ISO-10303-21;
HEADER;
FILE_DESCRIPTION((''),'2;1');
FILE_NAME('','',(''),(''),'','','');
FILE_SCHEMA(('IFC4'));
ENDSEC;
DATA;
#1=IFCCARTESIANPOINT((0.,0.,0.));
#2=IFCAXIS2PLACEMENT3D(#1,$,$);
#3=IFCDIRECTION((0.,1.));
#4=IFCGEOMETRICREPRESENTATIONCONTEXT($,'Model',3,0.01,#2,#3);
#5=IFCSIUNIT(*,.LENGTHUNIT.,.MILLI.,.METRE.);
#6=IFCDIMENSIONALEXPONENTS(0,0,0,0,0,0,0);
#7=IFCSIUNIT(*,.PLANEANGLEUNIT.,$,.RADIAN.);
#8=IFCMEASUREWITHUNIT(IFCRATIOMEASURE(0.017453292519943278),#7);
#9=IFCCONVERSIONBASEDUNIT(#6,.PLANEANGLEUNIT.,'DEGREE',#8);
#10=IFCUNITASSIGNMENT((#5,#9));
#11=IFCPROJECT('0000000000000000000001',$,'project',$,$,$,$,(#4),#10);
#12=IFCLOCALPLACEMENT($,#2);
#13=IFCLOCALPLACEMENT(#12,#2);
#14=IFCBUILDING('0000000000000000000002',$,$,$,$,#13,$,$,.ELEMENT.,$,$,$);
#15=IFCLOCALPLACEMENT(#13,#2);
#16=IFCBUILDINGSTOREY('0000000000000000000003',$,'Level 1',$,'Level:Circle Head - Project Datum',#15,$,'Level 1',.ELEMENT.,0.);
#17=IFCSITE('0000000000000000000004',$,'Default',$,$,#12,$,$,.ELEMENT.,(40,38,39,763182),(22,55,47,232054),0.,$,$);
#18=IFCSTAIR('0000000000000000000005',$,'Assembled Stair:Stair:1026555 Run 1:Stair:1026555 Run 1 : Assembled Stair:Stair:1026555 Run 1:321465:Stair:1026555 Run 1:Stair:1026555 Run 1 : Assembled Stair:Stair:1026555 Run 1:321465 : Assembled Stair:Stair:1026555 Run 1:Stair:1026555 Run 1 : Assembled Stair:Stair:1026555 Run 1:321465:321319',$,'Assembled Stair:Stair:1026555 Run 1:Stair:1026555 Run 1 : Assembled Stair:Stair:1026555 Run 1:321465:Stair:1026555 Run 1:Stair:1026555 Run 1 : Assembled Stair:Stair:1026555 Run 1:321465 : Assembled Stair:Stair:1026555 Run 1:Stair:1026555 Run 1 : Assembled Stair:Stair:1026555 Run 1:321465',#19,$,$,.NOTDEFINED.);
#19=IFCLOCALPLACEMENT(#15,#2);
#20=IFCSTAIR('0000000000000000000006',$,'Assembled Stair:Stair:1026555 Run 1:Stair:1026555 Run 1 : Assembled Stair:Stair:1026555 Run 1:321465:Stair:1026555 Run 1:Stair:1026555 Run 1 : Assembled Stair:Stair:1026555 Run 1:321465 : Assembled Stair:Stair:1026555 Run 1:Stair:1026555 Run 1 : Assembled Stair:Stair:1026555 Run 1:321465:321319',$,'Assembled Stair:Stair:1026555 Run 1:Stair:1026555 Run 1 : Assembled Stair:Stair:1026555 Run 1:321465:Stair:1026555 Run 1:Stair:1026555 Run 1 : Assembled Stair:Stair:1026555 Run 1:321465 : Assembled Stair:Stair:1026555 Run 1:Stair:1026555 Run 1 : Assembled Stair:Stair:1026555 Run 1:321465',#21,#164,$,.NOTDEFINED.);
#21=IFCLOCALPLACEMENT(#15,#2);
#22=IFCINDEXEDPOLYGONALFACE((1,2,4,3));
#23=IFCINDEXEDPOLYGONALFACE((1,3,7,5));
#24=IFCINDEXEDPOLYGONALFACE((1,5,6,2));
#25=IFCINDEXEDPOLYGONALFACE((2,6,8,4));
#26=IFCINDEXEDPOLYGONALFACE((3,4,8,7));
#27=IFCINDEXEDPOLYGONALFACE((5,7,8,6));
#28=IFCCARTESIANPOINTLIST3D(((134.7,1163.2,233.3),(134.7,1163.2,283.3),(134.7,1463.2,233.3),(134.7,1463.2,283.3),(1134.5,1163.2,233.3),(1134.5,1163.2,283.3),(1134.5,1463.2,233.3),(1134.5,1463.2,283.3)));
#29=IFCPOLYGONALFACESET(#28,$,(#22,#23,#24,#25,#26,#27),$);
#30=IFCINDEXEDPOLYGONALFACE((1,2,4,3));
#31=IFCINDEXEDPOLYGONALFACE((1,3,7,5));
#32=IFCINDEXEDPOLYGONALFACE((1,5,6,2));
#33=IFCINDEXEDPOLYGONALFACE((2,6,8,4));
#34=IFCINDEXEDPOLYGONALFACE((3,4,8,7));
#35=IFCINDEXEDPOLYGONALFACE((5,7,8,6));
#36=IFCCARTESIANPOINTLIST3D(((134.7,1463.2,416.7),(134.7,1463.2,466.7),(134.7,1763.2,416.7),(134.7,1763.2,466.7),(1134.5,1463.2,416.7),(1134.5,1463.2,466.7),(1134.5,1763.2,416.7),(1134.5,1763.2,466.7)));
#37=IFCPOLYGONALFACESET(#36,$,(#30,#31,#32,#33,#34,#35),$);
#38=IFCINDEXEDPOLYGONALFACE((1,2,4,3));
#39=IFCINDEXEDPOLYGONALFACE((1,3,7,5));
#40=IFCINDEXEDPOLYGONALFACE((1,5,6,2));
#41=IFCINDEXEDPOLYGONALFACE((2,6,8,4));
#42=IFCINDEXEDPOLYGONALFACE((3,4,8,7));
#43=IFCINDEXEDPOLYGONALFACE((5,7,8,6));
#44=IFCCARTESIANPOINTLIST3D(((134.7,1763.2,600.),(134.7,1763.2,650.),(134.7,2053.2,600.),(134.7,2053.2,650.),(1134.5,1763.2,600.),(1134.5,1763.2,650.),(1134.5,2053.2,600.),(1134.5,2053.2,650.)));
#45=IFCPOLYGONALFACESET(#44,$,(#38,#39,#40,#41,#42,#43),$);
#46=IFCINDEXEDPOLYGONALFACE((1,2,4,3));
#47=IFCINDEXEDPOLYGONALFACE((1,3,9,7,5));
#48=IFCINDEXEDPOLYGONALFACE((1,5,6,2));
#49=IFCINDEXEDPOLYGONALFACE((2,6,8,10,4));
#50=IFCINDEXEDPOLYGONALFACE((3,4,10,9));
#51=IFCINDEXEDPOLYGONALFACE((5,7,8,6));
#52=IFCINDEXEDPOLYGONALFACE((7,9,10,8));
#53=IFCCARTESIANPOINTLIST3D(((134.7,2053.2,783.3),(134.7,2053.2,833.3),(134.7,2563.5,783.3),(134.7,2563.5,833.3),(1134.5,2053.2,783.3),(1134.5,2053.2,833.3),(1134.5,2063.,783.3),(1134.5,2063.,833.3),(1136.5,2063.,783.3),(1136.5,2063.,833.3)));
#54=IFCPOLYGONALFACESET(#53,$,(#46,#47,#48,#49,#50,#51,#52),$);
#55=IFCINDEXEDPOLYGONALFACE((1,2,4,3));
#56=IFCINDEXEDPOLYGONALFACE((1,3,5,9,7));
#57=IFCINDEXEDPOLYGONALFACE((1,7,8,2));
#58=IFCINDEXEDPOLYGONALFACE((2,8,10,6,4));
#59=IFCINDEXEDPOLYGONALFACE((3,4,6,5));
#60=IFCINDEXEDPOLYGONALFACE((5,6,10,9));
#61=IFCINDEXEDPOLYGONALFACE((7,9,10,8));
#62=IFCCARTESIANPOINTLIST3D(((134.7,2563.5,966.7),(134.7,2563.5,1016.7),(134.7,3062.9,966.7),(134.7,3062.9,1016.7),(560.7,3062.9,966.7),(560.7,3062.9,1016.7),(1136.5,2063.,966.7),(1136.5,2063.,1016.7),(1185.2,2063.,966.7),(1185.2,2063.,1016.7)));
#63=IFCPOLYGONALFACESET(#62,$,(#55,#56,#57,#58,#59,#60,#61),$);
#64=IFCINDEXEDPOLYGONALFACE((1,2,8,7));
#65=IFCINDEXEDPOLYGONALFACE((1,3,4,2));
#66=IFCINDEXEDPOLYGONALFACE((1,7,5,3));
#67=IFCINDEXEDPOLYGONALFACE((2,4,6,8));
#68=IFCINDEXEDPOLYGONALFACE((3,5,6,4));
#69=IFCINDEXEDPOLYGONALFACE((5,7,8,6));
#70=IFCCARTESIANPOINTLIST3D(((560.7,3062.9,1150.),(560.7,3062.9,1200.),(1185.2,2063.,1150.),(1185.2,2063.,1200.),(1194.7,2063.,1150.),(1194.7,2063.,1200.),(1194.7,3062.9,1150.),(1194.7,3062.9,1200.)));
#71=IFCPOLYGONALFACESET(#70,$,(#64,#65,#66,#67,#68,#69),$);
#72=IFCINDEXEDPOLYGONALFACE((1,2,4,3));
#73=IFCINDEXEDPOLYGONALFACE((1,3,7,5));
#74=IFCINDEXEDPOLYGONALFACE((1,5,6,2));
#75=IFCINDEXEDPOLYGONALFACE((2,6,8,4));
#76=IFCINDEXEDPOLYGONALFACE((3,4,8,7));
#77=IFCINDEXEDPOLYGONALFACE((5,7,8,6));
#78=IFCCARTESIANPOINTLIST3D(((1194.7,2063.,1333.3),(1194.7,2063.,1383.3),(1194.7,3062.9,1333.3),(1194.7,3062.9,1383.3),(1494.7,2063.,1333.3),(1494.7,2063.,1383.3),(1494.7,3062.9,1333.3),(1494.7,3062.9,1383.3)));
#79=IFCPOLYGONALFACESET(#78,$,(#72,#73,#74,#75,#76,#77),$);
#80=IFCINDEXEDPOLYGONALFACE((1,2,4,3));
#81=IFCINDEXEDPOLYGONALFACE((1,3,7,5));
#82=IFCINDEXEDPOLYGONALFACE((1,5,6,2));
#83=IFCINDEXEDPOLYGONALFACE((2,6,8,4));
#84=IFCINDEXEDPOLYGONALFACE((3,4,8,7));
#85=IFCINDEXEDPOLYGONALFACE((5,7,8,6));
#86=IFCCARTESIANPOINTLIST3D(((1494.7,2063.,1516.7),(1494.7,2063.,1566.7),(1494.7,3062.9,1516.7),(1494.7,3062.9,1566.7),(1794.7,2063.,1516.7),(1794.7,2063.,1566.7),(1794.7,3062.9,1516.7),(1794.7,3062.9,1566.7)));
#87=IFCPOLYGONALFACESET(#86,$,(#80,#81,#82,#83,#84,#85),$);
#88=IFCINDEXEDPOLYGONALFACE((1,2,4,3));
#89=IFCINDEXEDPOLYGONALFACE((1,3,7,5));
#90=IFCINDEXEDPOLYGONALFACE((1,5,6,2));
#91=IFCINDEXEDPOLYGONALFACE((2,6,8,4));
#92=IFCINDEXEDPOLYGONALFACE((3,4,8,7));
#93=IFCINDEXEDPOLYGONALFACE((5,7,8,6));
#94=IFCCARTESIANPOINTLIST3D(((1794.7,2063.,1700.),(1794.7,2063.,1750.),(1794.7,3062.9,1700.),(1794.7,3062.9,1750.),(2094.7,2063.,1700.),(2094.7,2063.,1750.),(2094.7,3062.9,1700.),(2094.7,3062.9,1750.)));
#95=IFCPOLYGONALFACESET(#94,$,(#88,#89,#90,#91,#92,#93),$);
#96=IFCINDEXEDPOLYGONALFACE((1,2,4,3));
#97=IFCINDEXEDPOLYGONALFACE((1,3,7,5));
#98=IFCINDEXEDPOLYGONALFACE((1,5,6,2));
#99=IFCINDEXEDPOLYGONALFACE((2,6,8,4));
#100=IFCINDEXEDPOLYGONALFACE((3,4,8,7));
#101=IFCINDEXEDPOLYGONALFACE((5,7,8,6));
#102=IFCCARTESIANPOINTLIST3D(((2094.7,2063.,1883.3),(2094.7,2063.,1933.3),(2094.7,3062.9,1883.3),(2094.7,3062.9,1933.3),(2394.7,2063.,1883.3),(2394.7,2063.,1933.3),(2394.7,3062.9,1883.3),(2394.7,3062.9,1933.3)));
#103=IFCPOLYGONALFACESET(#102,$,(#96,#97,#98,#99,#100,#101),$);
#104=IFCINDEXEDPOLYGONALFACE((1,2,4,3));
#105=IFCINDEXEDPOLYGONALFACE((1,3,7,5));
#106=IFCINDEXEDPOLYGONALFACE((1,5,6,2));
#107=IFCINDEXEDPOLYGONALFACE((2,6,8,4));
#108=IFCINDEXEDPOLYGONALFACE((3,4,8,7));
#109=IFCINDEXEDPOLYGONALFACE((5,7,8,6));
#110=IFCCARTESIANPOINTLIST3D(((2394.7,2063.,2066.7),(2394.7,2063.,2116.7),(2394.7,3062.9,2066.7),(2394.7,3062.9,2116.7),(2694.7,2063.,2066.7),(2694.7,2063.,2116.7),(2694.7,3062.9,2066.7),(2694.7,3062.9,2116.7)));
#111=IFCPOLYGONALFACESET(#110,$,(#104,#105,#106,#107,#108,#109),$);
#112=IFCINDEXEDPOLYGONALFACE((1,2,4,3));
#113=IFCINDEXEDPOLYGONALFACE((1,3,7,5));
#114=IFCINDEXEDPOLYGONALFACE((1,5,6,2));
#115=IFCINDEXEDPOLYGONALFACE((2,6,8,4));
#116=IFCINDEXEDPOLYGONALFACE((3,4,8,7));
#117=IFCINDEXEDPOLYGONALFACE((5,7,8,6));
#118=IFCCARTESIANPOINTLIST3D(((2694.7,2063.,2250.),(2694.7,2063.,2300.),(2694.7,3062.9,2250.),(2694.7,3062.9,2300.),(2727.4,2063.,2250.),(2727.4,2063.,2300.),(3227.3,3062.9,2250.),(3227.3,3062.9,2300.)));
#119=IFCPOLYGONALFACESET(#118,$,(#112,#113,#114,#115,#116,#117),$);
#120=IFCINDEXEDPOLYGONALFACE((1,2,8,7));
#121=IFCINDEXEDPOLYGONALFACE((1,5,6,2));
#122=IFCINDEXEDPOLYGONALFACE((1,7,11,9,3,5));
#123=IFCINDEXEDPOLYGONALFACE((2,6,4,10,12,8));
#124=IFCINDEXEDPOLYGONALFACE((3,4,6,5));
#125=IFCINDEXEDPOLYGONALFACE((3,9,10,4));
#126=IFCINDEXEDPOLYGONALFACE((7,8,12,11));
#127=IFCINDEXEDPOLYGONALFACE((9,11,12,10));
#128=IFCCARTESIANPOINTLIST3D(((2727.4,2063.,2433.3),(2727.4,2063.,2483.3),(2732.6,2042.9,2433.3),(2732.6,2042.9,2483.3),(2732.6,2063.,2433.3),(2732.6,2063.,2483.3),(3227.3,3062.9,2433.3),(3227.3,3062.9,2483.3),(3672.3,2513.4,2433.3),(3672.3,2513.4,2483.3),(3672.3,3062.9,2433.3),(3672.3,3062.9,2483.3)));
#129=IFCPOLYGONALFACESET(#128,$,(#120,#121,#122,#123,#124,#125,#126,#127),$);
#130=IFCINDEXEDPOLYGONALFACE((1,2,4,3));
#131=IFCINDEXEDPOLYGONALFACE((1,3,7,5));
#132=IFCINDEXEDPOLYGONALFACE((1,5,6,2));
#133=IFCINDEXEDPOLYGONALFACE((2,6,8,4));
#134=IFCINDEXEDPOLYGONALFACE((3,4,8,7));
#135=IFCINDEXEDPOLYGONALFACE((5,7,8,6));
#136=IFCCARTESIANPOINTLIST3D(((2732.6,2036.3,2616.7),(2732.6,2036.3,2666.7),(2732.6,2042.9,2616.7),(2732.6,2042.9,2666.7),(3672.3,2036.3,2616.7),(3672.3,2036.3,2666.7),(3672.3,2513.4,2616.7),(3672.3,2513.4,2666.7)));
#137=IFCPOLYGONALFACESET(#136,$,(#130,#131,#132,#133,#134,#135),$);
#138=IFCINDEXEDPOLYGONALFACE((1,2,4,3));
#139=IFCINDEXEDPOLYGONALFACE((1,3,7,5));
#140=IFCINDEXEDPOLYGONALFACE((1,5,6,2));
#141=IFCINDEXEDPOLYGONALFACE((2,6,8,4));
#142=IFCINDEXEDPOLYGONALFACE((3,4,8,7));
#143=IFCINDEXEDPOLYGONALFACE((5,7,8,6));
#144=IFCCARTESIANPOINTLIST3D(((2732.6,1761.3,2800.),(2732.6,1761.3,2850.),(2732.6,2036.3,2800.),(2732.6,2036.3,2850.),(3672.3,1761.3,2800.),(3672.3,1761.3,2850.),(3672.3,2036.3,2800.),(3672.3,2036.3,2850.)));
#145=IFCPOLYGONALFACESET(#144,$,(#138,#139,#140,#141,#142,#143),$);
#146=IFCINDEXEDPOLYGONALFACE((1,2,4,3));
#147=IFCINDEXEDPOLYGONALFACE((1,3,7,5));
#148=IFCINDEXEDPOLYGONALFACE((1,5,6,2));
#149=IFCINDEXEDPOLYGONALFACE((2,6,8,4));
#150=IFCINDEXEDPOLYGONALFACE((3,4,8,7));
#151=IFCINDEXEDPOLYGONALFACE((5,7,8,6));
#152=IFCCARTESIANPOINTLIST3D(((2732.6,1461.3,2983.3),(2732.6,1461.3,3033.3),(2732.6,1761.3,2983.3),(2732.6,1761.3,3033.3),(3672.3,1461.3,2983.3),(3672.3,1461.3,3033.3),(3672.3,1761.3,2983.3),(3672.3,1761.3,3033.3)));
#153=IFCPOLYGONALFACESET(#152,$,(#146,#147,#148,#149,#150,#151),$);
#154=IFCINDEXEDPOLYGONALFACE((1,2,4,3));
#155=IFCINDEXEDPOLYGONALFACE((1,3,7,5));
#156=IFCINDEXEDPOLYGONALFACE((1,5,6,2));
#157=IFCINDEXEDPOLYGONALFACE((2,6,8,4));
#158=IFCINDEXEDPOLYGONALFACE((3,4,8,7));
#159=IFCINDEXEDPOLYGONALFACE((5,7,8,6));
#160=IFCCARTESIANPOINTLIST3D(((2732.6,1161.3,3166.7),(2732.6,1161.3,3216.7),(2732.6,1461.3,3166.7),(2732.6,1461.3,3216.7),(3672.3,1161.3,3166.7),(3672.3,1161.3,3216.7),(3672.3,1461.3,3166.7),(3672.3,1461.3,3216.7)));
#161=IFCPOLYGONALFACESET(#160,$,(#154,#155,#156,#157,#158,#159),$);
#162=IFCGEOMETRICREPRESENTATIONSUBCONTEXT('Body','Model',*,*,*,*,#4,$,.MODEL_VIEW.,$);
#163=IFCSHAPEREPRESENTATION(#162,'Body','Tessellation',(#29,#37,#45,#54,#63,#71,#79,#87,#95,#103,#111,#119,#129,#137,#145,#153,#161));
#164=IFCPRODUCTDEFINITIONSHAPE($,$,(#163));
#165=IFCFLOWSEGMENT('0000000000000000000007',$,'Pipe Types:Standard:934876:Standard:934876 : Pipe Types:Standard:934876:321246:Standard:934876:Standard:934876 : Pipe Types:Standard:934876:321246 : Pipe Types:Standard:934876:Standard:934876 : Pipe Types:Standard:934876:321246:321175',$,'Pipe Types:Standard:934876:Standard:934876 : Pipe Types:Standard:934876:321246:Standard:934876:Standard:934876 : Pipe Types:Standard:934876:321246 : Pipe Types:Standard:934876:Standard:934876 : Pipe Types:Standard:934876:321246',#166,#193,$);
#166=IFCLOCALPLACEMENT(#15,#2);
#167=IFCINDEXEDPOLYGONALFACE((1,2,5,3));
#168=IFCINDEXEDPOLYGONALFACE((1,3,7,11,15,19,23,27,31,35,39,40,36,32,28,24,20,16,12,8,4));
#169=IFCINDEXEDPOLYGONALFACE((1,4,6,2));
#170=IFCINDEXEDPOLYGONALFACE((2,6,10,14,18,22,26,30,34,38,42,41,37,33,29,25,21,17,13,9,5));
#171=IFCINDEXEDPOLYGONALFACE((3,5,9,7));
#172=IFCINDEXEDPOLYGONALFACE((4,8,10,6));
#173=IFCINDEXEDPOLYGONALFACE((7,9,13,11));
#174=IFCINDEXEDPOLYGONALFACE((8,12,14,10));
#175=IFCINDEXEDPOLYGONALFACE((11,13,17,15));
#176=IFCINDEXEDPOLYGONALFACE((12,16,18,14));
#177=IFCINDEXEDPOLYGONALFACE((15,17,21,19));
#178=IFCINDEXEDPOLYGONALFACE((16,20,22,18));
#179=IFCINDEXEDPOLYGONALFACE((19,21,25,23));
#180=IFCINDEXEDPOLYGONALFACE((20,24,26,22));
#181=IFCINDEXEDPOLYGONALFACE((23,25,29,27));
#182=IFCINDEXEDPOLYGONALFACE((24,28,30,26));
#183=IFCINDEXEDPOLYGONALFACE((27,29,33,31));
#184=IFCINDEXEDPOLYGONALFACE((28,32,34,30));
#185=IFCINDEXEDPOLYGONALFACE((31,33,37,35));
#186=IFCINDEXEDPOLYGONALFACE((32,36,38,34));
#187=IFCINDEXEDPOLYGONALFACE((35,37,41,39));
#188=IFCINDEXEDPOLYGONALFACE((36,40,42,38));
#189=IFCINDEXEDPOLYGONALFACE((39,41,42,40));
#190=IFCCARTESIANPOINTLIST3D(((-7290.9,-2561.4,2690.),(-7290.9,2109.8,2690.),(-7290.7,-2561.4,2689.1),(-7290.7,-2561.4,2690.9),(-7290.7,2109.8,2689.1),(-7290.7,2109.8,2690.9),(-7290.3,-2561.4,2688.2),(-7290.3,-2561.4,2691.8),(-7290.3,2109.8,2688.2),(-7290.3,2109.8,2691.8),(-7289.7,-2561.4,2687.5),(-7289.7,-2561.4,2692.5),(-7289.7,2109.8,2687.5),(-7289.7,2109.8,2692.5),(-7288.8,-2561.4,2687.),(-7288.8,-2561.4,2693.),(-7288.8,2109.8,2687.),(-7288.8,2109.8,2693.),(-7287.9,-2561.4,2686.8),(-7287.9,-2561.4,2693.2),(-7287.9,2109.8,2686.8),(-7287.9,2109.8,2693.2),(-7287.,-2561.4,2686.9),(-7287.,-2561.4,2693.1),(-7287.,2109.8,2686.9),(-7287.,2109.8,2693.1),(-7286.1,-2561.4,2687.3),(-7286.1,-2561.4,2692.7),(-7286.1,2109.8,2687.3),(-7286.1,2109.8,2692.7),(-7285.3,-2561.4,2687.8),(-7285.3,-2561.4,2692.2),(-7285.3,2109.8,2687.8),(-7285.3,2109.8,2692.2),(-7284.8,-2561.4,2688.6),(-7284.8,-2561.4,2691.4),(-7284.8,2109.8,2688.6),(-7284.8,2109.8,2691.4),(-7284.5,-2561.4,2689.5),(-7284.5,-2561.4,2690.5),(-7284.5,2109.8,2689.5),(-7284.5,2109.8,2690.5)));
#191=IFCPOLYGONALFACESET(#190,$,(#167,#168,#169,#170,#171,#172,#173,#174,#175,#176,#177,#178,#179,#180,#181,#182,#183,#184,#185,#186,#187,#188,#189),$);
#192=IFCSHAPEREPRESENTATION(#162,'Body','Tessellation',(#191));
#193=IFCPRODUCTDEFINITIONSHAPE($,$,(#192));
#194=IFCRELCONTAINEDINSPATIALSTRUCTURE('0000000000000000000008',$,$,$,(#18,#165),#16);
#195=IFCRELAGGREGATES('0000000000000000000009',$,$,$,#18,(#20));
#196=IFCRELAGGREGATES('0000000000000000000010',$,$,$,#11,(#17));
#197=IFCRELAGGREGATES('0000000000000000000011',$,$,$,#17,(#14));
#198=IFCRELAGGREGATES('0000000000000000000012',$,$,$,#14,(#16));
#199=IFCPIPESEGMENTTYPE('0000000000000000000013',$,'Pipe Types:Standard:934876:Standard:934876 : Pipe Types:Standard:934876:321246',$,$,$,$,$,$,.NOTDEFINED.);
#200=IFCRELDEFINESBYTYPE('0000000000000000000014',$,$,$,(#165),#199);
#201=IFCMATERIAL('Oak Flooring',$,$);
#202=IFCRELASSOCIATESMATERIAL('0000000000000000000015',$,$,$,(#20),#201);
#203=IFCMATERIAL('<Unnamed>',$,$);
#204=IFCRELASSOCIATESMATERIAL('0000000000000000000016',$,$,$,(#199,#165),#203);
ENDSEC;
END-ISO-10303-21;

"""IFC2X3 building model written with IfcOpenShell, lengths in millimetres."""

from ifc_helpers import new_model, entity, si_unit, converted_unit, direction, frame, frame_2d, origin, origin_2d_with_axis, place, context, subcontext, project, spatial, polyline, rectangle, circle, outline, extrude, source, transform, mapped, material, type_object, type_shapes, element, aggregate, save


model = new_model("IFC2X3")

# Units and contexts
model_context = context("Model", 3, precision=0.01, world=origin(), true_north=direction((0.0, 1.0)))
body_context = subcontext(model_context, "Body", "Model", "MODEL_VIEW")
ifc_project = project(units=[si_unit("LENGTHUNIT", "METRE", prefix="MILLI"), converted_unit("PLANEANGLEUNIT", "DEGREE", entity("IfcRatioMeasure", 0.017453292519943278), si_unit("PLANEANGLEUNIT", "RADIAN"), dimensions=[0, 0, 0, 0, 0, 0, 0])], contexts=[model_context])

# Site, building, storey
site_placement = place(None, origin())
site = spatial("IfcSite", under=ifc_project, at=site_placement, Name="Default", CompositionType="ELEMENT", RefLatitude=(40, 38, 39, 763182), RefLongitude=(22, 55, 47, 232054), RefElevation=0.0)
building_placement = place(site_placement, origin())
building = spatial("IfcBuilding", under=site, at=building_placement, CompositionType="ELEMENT")
storey_placement = place(building_placement, origin())
storey = spatial("IfcBuildingStorey", under=building, at=storey_placement, Name="Level 1", ObjectType="Level:Circle Head - Project Datum", LongName="Level 1", CompositionType="ELEMENT", Elevation=0.0)

# Stairs
stair_1_placement = place(storey_placement, origin())
stair_1 = element("IfcStair", 1, at=stair_1_placement, inside=storey, Name="Assembled Stair:Stair:1026555 Run 1:Stair:1026555 Run 1 : Assembled Stair:Stair:1026555 Run 1:321465:Stair:1026555 Run 1:Stair:1026555 Run 1 : Assembled Stair:Stair:1026555 Run 1:321465 : Assembled Stair:Stair:1026555 Run 1:Stair:1026555 Run 1 : Assembled Stair:Stair:1026555 Run 1:321465:321319", ObjectType="Assembled Stair:Stair:1026555 Run 1:Stair:1026555 Run 1 : Assembled Stair:Stair:1026555 Run 1:321465:Stair:1026555 Run 1:Stair:1026555 Run 1 : Assembled Stair:Stair:1026555 Run 1:321465 : Assembled Stair:Stair:1026555 Run 1:Stair:1026555 Run 1 : Assembled Stair:Stair:1026555 Run 1:321465", ShapeType="NOTDEFINED")
ifc_material_1 = material(Name="Oak Flooring")
stair_2_placement = place(stair_1_placement, origin())
stair_2 = element("IfcStair", 2, at=stair_2_placement, material=ifc_material_1, Name="Assembled Stair:Stair:1026555 Run 1:Stair:1026555 Run 1 : Assembled Stair:Stair:1026555 Run 1:321465:Stair:1026555 Run 1:Stair:1026555 Run 1 : Assembled Stair:Stair:1026555 Run 1:321465 : Assembled Stair:Stair:1026555 Run 1:Stair:1026555 Run 1 : Assembled Stair:Stair:1026555 Run 1:321465:321319", ObjectType="Assembled Stair:Stair:1026555 Run 1:Stair:1026555 Run 1 : Assembled Stair:Stair:1026555 Run 1:321465:Stair:1026555 Run 1:Stair:1026555 Run 1 : Assembled Stair:Stair:1026555 Run 1:321465 : Assembled Stair:Stair:1026555 Run 1:Stair:1026555 Run 1 : Assembled Stair:Stair:1026555 Run 1:321465", ShapeType="NOTDEFINED", context=body_context, shape_type="SweptSolid", body=[
    extrude(rectangle(XDim=300.0, YDim=999.8, at=frame_2d((0.0, 0.0), x_axis=(1.0, 0.0))), frame((634.6, 1313.2, 233.3), z_axis=(0.0, 0.0, 1.0), x_axis=(0.0, 1.0, 0.0)), (0.0, 0.0, 1.0), 50.0),
    extrude(rectangle(XDim=300.0, YDim=999.8, at=origin_2d_with_axis()), frame((634.6, 1613.2, 416.7), z_axis=(0.0, 0.0, 1.0), x_axis=(0.0, 1.0, 0.0)), (0.0, 0.0, 1.0), 50.0),
    extrude(rectangle(XDim=290.0, YDim=999.8, at=frame_2d((0.0, 0.0), x_axis=(1.0, 0.0))), frame((634.6, 1908.2, 600.0), z_axis=(0.0, 0.0, 1.0), x_axis=(0.0, 1.0, 0.0)), (0.0, 0.0, 1.0), 50.0),
    extrude(outline(polyline([(-106.0, 399.5), (-106.0, -600.3), (404.3, -600.3), (-96.1, 401.5), (-96.1, 399.5), (-106.0, 399.5)])), frame((735.0, 2159.2, 783.3), z_axis=(0.0, 0.0, -1.0), x_axis=(0.0, 1.0, 0.0)), (0.0, 0.0, -1.0), 50.0),
    extrude(outline(polyline([(-443.6, -221.2), (676.2, -221.2), (719.8, -199.4), (-285.7, 416.0), (-666.8, 225.7), (-443.6, -221.2)])), frame((630.4, 2563.1, 966.7), z_axis=(0.0, 0.0, 1.0), x_axis=(0.894584, -0.446899, 0.0)), (0.0, 0.0, 1.0), 50.0),
    extrude(outline(polyline([(151.4, -499.9), (160.9, -499.9), (160.9, 499.9), (-473.1, 499.9), (151.4, -499.9)])), frame((1033.8, 2563.0, 1150.0)), (0.0, 0.0, 1.0), 50.0),
    extrude(rectangle(XDim=300.0, YDim=999.9, at=frame_2d((0.0, 0.0), x_axis=(1.0, 0.0))), frame((1344.7, 2563.0, 1333.3)), (0.0, 0.0, 1.0), 50.0),
    extrude(rectangle(XDim=300.0, YDim=999.9, at=frame_2d((0.0, 0.0), x_axis=(1.0, 0.0))), frame((1644.7, 2563.0, 1516.7)), (0.0, 0.0, 1.0), 50.0),
    extrude(rectangle(XDim=300.0, YDim=999.9, at=frame_2d((0.0, 0.0), x_axis=(1.0, 0.0))), frame((1944.7, 2563.0, 1700.0)), (0.0, 0.0, 1.0), 50.0),
    extrude(rectangle(XDim=300.0, YDim=999.9, at=frame_2d((0.0, 0.0), x_axis=(1.0, 0.0))), frame((2244.7, 2563.0, 1883.3)), (0.0, 0.0, 1.0), 50.0),
    extrude(rectangle(XDim=300.0, YDim=999.9, at=frame_2d((0.0, 0.0), x_axis=(1.0, 0.0))), frame((2544.7, 2563.0, 2066.7)), (0.0, 0.0, 1.0), 50.0),
    extrude(outline(polyline([(-141.3, -499.9), (-108.6, -499.9), (391.3, 499.9), (-141.3, 499.9), (-141.3, -499.9)])), frame((2836.0, 2563.0, 2250.0)), (0.0, 0.0, 1.0), 50.0),
    extrude(outline(polyline([(-576.8, -176.7), (541.1, -176.7), (538.8, -172.0), (556.8, -163.0), (-284.2, 467.1), (-775.8, 221.3), (-576.8, -176.7)])), frame((3127.4, 2468.0, 2433.3), z_axis=(0.0, 0.0, 1.0), x_axis=(-0.447218, -0.894425, 0.0)), (0.0, 0.0, 1.0), 50.0),
    extrude(outline(polyline([(114.3, -469.8), (120.9, -469.8), (120.9, 469.8), (-356.2, 469.8), (114.3, -469.8)])), frame((3202.4, 2157.2, 2616.7), z_axis=(0.0, 0.0, 1.0), x_axis=(0.0, -1.0, 0.0)), (0.0, 0.0, 1.0), 50.0),
    extrude(rectangle(XDim=275.0, YDim=939.7, at=frame_2d((0.0, 0.0), x_axis=(1.0, 0.0))), frame((3202.4, 1898.8, 2800.0), z_axis=(0.0, 0.0, 1.0), x_axis=(0.0, -1.0, 0.0)), (0.0, 0.0, 1.0), 50.0),
    extrude(rectangle(XDim=300.0, YDim=939.7, at=frame_2d((0.0, 0.0), x_axis=(1.0, 0.0))), frame((3202.4, 1611.3, 2983.3), z_axis=(0.0, 0.0, 1.0), x_axis=(0.0, -1.0, 0.0)), (0.0, 0.0, 1.0), 50.0),
    extrude(rectangle(XDim=300.0, YDim=939.7, at=frame_2d((0.0, 0.0), x_axis=(1.0, 0.0))), frame((3202.4, 1311.3, 3166.7), z_axis=(0.0, 0.0, 1.0), x_axis=(0.0, -1.0, 0.0)), (0.0, 0.0, 1.0), 50.0),
])
aggregate(stair_1, [stair_2])

# Flow segment
ifc_material_2 = material(Name="<Unnamed>")
pipe_segment_type_1 = type_object("IfcPipeSegmentType", Name="Pipe Types:Standard:934876:Standard:934876 : Pipe Types:Standard:934876:321246", PredefinedType="NOTDEFINED", material=ifc_material_2)
shared_shape_1 = source(origin(), body_context, "Body", "SweptSolid", [
    extrude(circle(Radius=3.2, at=origin_2d_with_axis()), frame((-7287.7, -2561.4, 2690.0), z_axis=(0.0, 1.0, 0.0), x_axis=(-1.0, 0.0, 0.0)), (0.0, 0.0, 1.0), 4671.2),
])
type_shapes(pipe_segment_type_1, [shared_shape_1])
flow_segment_1_placement = place(storey_placement, origin())
element("IfcFlowSegment", 3, at=flow_segment_1_placement, inside=storey, type_object=pipe_segment_type_1, material=ifc_material_2, Name="Pipe Types:Standard:934876:Standard:934876 : Pipe Types:Standard:934876:321246:Standard:934876:Standard:934876 : Pipe Types:Standard:934876:321246 : Pipe Types:Standard:934876:Standard:934876 : Pipe Types:Standard:934876:321246:321175", ObjectType="Pipe Types:Standard:934876:Standard:934876 : Pipe Types:Standard:934876:321246:Standard:934876:Standard:934876 : Pipe Types:Standard:934876:321246 : Pipe Types:Standard:934876:Standard:934876 : Pipe Types:Standard:934876:321246", context=body_context, shape_type="MappedRepresentation", body=[
    mapped(shared_shape_1, transform((0.0, 0.0, 0.0), scale=1.0)),
])

save(model, "model.ifc")
